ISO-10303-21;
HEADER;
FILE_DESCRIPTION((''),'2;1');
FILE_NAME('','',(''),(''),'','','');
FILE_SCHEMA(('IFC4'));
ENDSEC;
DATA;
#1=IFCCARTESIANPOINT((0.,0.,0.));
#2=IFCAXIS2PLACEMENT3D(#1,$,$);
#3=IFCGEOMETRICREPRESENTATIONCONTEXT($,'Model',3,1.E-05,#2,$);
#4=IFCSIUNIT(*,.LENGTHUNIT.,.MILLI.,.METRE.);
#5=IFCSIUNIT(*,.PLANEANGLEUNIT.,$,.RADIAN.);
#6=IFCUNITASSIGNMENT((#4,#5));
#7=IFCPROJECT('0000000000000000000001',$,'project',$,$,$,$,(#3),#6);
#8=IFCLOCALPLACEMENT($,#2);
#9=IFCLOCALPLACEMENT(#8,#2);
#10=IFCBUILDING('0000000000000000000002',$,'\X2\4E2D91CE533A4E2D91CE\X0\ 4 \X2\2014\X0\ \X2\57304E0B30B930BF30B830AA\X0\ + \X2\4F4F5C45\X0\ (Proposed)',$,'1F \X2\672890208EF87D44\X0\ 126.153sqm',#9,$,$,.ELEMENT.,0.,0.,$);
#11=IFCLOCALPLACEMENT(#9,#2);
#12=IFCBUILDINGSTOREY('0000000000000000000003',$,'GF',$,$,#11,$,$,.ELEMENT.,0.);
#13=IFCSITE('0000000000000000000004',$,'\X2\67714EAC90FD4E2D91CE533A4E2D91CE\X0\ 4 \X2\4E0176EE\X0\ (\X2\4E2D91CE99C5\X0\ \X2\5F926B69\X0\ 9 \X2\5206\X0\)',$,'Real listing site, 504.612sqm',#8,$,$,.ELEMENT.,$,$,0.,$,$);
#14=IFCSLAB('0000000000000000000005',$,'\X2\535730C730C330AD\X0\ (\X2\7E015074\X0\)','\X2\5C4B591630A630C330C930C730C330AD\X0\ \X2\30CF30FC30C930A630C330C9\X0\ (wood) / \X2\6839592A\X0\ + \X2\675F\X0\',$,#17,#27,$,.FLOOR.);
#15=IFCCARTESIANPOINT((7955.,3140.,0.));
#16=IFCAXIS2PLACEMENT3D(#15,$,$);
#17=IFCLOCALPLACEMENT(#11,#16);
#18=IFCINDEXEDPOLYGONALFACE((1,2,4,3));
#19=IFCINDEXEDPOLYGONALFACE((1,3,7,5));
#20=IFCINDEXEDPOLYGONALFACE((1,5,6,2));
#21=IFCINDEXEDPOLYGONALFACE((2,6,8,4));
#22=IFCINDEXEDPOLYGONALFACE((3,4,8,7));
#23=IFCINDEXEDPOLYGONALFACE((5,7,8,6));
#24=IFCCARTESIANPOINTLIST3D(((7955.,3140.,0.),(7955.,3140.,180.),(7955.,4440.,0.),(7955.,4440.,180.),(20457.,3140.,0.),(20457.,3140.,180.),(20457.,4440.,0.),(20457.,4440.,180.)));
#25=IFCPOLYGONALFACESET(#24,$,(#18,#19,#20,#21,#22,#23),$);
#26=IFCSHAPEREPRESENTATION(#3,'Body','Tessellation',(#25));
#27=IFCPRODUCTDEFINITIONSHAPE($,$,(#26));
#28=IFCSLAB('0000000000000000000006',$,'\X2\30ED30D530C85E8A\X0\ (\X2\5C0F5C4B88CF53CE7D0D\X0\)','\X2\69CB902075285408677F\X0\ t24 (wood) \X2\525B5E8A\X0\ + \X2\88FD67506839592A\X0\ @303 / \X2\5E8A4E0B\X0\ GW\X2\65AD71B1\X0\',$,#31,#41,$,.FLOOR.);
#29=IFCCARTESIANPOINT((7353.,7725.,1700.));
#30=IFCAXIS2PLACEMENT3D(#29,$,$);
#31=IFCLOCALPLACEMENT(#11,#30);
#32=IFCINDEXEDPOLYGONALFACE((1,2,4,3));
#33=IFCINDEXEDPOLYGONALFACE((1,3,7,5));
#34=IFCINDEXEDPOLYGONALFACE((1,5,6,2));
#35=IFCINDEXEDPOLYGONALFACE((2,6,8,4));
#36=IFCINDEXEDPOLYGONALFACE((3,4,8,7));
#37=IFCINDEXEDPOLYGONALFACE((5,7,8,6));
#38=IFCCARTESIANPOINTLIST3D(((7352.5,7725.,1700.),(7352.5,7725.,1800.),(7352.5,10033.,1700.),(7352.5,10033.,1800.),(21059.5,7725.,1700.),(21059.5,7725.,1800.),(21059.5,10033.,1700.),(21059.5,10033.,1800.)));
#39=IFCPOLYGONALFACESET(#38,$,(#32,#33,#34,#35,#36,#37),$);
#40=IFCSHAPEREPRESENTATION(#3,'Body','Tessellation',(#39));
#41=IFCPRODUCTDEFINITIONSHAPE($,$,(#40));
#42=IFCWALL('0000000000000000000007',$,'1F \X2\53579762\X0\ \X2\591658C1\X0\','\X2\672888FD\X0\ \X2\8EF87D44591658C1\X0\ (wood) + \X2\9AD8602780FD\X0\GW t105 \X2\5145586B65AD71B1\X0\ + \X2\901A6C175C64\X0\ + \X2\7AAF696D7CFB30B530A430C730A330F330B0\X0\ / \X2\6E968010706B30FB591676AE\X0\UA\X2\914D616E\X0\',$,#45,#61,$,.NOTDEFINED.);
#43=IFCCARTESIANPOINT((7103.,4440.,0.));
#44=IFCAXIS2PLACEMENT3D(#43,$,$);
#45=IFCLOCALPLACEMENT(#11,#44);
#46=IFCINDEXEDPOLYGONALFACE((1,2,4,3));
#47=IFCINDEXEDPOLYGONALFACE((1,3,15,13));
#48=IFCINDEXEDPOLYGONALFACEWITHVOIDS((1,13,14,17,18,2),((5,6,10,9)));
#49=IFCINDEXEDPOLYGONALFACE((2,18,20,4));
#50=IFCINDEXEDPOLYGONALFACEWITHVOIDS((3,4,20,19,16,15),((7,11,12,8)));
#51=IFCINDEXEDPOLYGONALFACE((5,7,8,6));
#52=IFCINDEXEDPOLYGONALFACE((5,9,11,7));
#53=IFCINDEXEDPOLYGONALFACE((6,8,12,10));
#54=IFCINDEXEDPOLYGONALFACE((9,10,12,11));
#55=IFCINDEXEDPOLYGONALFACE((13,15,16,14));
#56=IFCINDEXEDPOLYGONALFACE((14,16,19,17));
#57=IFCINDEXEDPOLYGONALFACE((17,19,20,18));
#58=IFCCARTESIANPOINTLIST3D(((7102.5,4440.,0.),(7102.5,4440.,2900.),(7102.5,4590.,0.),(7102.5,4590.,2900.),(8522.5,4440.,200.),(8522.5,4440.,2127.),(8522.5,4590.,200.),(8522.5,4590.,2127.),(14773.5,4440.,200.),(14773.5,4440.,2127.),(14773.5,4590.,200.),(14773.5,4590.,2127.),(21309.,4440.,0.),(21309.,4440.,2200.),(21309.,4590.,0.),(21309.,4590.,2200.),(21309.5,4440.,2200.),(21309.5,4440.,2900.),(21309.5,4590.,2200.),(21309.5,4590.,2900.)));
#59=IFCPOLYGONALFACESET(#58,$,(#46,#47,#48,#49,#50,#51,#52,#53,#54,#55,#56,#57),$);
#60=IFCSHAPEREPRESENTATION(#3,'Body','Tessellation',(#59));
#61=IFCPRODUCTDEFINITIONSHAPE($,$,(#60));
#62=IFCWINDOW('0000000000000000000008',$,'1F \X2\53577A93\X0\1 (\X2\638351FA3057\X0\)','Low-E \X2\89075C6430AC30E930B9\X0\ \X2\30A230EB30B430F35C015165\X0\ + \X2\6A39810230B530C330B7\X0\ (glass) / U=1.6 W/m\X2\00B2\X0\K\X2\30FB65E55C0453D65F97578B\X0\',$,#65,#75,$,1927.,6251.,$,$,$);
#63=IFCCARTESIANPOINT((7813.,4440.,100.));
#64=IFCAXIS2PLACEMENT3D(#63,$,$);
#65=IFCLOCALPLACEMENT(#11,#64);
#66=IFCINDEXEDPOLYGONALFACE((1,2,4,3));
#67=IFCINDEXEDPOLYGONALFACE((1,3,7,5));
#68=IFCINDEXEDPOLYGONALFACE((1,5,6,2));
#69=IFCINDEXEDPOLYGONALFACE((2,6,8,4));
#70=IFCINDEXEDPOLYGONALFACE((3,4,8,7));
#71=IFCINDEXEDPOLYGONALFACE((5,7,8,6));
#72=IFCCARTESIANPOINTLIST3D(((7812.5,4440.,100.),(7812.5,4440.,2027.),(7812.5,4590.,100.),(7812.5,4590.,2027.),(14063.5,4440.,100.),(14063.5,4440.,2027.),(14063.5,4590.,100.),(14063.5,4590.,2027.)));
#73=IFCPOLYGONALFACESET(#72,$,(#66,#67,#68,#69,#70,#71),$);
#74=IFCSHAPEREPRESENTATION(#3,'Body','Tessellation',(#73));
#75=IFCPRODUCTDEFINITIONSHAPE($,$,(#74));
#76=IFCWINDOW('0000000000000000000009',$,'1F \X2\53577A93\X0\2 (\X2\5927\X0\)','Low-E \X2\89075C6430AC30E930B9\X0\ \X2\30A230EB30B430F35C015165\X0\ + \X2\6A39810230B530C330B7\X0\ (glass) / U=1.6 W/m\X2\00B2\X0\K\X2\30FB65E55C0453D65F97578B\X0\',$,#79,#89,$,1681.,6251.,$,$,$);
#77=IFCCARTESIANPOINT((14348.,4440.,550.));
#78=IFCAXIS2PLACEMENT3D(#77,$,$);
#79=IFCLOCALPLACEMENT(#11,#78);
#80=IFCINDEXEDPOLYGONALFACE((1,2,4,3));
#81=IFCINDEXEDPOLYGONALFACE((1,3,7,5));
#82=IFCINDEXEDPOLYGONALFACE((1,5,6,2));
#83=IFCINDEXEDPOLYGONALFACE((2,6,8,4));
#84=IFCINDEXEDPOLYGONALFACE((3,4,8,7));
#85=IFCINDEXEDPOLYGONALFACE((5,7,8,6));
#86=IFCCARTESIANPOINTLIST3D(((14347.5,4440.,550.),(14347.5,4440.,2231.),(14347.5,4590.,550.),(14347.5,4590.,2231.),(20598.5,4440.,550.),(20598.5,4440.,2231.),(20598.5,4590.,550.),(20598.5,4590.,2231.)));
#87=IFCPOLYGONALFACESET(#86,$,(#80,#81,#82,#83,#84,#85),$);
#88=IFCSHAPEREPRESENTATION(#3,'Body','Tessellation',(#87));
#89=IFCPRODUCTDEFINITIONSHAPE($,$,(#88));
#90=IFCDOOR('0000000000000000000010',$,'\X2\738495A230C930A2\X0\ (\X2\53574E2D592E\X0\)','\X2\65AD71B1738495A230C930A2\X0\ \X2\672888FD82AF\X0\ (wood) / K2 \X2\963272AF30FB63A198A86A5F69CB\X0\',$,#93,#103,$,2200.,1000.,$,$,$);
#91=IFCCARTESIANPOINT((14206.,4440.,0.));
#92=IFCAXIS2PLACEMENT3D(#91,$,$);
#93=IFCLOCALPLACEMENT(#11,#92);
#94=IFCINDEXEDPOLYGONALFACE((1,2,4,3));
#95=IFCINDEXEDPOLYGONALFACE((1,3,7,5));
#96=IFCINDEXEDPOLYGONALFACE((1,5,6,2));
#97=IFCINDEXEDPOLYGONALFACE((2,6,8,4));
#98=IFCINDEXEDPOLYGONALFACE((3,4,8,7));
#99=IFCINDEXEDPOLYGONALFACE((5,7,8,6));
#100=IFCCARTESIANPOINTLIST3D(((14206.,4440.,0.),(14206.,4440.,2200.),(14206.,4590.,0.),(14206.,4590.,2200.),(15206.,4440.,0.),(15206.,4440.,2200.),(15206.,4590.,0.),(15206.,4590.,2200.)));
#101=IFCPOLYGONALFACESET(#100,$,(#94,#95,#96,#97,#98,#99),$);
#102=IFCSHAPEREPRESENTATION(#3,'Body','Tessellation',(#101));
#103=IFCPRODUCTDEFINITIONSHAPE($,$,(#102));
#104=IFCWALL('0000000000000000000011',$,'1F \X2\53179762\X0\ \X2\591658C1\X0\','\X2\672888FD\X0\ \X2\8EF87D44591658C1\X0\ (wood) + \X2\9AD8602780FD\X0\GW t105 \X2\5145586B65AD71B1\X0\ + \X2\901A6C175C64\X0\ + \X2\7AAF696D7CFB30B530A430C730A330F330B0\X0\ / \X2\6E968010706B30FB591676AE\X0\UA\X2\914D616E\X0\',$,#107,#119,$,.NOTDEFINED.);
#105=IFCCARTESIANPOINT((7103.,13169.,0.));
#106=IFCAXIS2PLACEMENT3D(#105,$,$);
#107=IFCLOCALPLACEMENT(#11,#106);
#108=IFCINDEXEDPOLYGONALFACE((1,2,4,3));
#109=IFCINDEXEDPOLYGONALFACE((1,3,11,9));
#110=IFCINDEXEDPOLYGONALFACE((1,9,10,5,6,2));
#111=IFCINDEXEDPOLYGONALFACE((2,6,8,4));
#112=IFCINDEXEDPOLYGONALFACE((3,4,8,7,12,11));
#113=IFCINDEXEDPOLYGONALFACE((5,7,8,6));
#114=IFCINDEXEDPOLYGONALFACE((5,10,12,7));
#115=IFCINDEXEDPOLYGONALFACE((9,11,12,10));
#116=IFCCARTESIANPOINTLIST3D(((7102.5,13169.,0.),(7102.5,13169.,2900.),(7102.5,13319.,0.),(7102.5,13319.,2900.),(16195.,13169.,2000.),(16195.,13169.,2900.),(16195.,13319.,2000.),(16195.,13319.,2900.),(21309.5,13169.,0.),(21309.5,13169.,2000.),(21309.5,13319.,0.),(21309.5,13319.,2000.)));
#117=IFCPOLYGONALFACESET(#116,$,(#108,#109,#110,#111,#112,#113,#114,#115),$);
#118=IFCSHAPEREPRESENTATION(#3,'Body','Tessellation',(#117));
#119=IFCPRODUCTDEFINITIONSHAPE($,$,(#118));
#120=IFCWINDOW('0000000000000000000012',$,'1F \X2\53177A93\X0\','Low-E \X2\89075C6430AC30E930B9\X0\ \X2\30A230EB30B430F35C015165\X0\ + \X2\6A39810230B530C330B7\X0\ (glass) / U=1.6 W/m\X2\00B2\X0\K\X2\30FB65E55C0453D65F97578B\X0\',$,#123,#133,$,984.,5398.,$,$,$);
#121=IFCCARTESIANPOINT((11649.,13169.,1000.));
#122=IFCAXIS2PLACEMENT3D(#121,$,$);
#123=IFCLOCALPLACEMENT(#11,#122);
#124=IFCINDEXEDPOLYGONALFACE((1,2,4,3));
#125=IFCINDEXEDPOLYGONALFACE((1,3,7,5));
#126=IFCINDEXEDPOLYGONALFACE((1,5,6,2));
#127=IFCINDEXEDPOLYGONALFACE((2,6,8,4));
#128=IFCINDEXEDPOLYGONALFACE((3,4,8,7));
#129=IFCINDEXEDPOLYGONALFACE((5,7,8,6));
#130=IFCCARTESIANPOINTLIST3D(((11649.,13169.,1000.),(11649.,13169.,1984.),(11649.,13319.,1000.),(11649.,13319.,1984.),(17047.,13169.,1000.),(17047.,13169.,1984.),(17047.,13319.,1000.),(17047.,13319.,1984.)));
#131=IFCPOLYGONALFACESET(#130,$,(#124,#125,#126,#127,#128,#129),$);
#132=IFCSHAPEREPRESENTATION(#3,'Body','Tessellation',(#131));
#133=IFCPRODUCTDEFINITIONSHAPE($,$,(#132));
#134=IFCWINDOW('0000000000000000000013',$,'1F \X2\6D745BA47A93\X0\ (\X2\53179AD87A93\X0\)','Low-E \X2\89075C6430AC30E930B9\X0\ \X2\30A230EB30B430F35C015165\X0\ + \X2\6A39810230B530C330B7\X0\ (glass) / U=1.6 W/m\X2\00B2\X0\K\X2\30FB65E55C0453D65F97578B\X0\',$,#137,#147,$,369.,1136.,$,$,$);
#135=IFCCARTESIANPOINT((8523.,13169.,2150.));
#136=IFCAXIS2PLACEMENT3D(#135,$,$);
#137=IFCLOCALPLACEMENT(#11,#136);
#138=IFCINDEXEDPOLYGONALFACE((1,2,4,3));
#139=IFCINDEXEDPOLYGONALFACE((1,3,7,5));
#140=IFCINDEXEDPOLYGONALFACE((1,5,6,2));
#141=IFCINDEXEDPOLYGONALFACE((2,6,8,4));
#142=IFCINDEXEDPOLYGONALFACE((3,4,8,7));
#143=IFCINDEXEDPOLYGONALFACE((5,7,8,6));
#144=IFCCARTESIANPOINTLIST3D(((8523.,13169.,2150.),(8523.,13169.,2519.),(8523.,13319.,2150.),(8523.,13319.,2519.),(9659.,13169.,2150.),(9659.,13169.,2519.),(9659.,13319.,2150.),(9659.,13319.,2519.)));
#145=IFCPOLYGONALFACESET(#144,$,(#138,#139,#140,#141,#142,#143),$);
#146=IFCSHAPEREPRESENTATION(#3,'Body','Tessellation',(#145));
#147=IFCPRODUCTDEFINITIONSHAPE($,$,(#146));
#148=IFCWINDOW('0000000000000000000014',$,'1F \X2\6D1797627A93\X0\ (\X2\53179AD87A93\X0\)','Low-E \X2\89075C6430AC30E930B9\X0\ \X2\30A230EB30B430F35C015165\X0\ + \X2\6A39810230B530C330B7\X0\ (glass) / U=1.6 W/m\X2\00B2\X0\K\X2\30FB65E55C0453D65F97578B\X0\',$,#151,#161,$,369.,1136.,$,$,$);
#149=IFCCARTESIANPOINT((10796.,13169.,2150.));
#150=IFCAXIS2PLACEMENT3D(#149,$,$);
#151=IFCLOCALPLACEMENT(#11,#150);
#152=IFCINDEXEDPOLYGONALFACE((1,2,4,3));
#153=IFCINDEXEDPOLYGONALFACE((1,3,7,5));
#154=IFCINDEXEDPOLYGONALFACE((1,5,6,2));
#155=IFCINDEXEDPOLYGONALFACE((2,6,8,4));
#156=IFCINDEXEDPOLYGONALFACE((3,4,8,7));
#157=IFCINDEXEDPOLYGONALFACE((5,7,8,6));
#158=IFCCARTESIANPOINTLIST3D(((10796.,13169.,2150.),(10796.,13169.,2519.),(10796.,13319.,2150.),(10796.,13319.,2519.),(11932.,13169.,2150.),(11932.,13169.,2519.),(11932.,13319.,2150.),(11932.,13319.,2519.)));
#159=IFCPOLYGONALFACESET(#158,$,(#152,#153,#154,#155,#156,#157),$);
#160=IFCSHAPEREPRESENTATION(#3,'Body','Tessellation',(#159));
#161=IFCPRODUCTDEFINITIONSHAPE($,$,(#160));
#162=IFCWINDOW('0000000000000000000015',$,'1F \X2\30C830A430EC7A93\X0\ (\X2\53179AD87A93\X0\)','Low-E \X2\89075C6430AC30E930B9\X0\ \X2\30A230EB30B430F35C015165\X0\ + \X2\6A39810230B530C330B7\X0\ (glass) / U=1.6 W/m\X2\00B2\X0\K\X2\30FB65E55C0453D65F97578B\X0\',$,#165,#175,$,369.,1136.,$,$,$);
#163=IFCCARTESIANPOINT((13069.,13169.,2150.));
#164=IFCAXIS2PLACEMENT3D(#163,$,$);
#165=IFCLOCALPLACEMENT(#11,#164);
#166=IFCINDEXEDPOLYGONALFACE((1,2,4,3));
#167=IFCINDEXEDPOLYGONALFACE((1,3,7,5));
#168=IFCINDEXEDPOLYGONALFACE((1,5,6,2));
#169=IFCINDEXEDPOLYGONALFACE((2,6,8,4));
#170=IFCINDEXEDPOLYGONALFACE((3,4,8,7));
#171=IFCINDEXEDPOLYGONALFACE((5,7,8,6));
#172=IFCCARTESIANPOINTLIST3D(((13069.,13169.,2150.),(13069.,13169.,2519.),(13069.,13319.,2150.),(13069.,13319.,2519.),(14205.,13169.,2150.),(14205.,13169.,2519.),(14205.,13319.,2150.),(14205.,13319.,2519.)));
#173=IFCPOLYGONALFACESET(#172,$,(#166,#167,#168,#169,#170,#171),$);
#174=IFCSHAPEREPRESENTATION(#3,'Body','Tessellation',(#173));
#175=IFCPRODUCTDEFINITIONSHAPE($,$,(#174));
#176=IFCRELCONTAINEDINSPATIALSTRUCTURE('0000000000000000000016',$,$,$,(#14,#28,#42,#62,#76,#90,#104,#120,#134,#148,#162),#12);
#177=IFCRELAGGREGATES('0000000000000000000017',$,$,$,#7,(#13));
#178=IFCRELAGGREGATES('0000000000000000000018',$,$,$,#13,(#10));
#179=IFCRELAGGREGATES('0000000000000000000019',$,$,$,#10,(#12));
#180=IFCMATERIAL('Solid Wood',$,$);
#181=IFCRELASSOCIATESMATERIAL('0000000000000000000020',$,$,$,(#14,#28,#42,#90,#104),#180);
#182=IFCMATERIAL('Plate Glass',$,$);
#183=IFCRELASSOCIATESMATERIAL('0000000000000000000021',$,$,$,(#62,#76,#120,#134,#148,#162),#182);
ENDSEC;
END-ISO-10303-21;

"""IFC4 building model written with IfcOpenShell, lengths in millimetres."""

from ifc_helpers import new_model, si_unit, frame, frame_2d, origin, place, context, project, spatial, rectangle, extrude, material, element, fill, save


model = new_model("IFC4")

# Units and contexts
model_context = context("Model", 3, precision=1e-05, world=origin())
ifc_project = project(units=[si_unit("LENGTHUNIT", "METRE", prefix="MILLI"), si_unit("PLANEANGLEUNIT", "RADIAN")], contexts=[model_context])

# Site, building, storey
site_placement = place(None, origin())
site = spatial("IfcSite", under=ifc_project, at=site_placement, Name="東京都中野区中野 4 丁目 (中野駅 徒歩 9 分)", ObjectType="Real listing site, 504.612sqm", CompositionType="ELEMENT", RefElevation=0.0)
building_placement = place(site_placement, origin())
building = spatial("IfcBuilding", under=site, at=building_placement, Name="中野区中野 4 — 地下スタジオ + 住居 (Proposed)", ObjectType="1F 木造軸組 126.153sqm", CompositionType="ELEMENT", ElevationOfRefHeight=0.0, ElevationOfTerrain=0.0)
storey_placement = place(building_placement, origin())
storey = spatial("IfcBuildingStorey", under=building, at=storey_placement, Name="GF", CompositionType="ELEMENT", Elevation=0.0)

# Slabs
ifc_material_1 = material(Name="Solid Wood")
slab_1_placement = place(storey_placement, frame((7955.0, 3140.0, 0.0)))
element("IfcSlab", 1, at=slab_1_placement, inside=storey, material=ifc_material_1, Name="南デッキ (縁側)", Description="屋外ウッドデッキ ハードウッド (wood) / 根太 + 束", PredefinedType="FLOOR", context=model_context, shape_type="SweptSolid", body=[
    extrude(rectangle(XDim=12502.0, YDim=1300.0, at=frame_2d((6251.0, 650.0))), frame((7955.0, 3140.0, 0.0)), (0.0, 0.0, 1.0), 180.0),
])
slab_2_placement = place(storey_placement, frame((7353.0, 7725.0, 1700.0)))
element("IfcSlab", 2, at=slab_2_placement, inside=storey, material=ifc_material_1, Name="ロフト床 (小屋裏収納)", Description="構造用合板 t24 (wood) 剛床 + 製材根太 @303 / 床下 GW断熱", PredefinedType="FLOOR", context=model_context, shape_type="SweptSolid", body=[
    extrude(rectangle(XDim=13707.0, YDim=2308.0, at=frame_2d((6853.0, 1154.0))), frame((7353.0, 7725.0, 1700.0)), (0.0, 0.0, 1.0), 100.0),
])

# Wall, openings, windows, door
wall_1_placement = place(storey_placement, frame((7103.0, 4440.0, 0.0)))
wall_1 = element("IfcWall", 3, at=wall_1_placement, inside=storey, material=ifc_material_1, Name="1F 南面 外壁", Description="木製 軸組外壁 (wood) + 高性能GW t105 充填断熱 + 通気層 + 窯業系サイディング / 準耐火・外皮UA配慮", PredefinedType="NOTDEFINED", context=model_context, shape_type="SweptSolid", body=[
    extrude(rectangle(XDim=14207.0, YDim=150.0, at=frame_2d((7103.0, 75.0))), frame((7103.0, 4440.0, 0.0)), (0.0, 0.0, 1.0), 2900.0),
])
opening_1_placement = place(storey_placement, frame((7813.0, 4440.0, 100.0)))
opening_1 = element("IfcOpeningElement", 4, at=opening_1_placement, cuts=wall_1, PredefinedType="NOTDEFINED", context=model_context, shape_type="SweptSolid", body=[
    extrude(rectangle(XDim=6251.0, YDim=150.0, at=frame_2d((3125.0, 75.0))), frame((7813.0, 4440.0, 100.0)), (0.0, 0.0, 1.0), 1927.0),
])
opening_2_placement = place(storey_placement, frame((14348.0, 4440.0, 550.0)))
opening_2 = element("IfcOpeningElement", 5, at=opening_2_placement, cuts=wall_1, PredefinedType="NOTDEFINED", context=model_context, shape_type="SweptSolid", body=[
    extrude(rectangle(XDim=6251.0, YDim=150.0, at=frame_2d((3125.0, 75.0))), frame((14348.0, 4440.0, 550.0)), (0.0, 0.0, 1.0), 1681.0),
])
opening_3_placement = place(storey_placement, frame((14206.0, 4440.0, 0.0)))
opening_3 = element("IfcOpeningElement", 6, at=opening_3_placement, cuts=wall_1, PredefinedType="NOTDEFINED", context=model_context, shape_type="SweptSolid", body=[
    extrude(rectangle(XDim=1000.0, YDim=150.0, at=frame_2d((500.0, 75.0))), frame((14206.0, 4440.0, 0.0)), (0.0, 0.0, 1.0), 2200.0),
])
ifc_material_2 = material(Name="Plate Glass")
window_1_placement = place(storey_placement, frame((7813.0, 4440.0, 100.0)))
window_1 = element("IfcWindow", 7, at=window_1_placement, inside=storey, material=ifc_material_2, Name="1F 南窓1 (掃出し)", Description="Low-E 複層ガラス アルゴン封入 + 樹脂サッシ (glass) / U=1.6 W/m²K・日射取得型", OverallHeight=1927.0, OverallWidth=6251.0, context=model_context, shape_type="SweptSolid", body=[
    extrude(rectangle(XDim=6251.0, YDim=150.0, at=frame_2d((3125.0, 75.0))), frame((7813.0, 4440.0, 100.0)), (0.0, 0.0, 1.0), 1927.0),
])
fill(opening_1, window_1)
window_2_placement = place(storey_placement, frame((14348.0, 4440.0, 550.0)))
window_2 = element("IfcWindow", 8, at=window_2_placement, inside=storey, material=ifc_material_2, Name="1F 南窓2 (大)", Description="Low-E 複層ガラス アルゴン封入 + 樹脂サッシ (glass) / U=1.6 W/m²K・日射取得型", OverallHeight=1681.0, OverallWidth=6251.0, context=model_context, shape_type="SweptSolid", body=[
    extrude(rectangle(XDim=6251.0, YDim=150.0, at=frame_2d((3125.0, 75.0))), frame((14348.0, 4440.0, 550.0)), (0.0, 0.0, 1.0), 1681.0),
])
fill(opening_2, window_2)
door_1_placement = place(storey_placement, frame((14206.0, 4440.0, 0.0)))
door_1 = element("IfcDoor", 9, at=door_1_placement, inside=storey, material=ifc_material_1, Name="玄関ドア (南中央)", Description="断熱玄関ドア 木製芯 (wood) / K2 防犯・採風機構", OverallHeight=2200.0, OverallWidth=1000.0, context=model_context, shape_type="SweptSolid", body=[
    extrude(rectangle(XDim=1000.0, YDim=150.0, at=frame_2d((500.0, 75.0))), frame((14206.0, 4440.0, 0.0)), (0.0, 0.0, 1.0), 2200.0),
])
fill(opening_3, door_1)

# Wall, openings, windows
wall_2_placement = place(storey_placement, frame((7103.0, 13169.0, 0.0)))
wall_2 = element("IfcWall", 10, at=wall_2_placement, inside=storey, material=ifc_material_1, Name="1F 北面 外壁", Description="木製 軸組外壁 (wood) + 高性能GW t105 充填断熱 + 通気層 + 窯業系サイディング / 準耐火・外皮UA配慮", PredefinedType="NOTDEFINED", context=model_context, shape_type="SweptSolid", body=[
    extrude(rectangle(XDim=14207.0, YDim=150.0, at=frame_2d((7103.0, 75.0))), frame((7103.0, 13169.0, 0.0)), (0.0, 0.0, 1.0), 2900.0),
])
opening_4_placement = place(storey_placement, frame((11649.0, 13169.0, 1000.0)))
opening_4 = element("IfcOpeningElement", 11, at=opening_4_placement, cuts=wall_2, PredefinedType="NOTDEFINED", context=model_context, shape_type="SweptSolid", body=[
    extrude(rectangle(XDim=5398.0, YDim=150.0, at=frame_2d((2699.0, 75.0))), frame((11649.0, 13169.0, 1000.0)), (0.0, 0.0, 1.0), 984.0),
])
opening_5_placement = place(storey_placement, frame((8523.0, 13169.0, 2150.0)))
opening_5 = element("IfcOpeningElement", 12, at=opening_5_placement, cuts=wall_2, PredefinedType="NOTDEFINED", context=model_context, shape_type="SweptSolid", body=[
    extrude(rectangle(XDim=1136.0, YDim=150.0, at=frame_2d((568.0, 75.0))), frame((8523.0, 13169.0, 2150.0)), (0.0, 0.0, 1.0), 369.0),
])
opening_6_placement = place(storey_placement, frame((10796.0, 13169.0, 2150.0)))
opening_6 = element("IfcOpeningElement", 13, at=opening_6_placement, cuts=wall_2, PredefinedType="NOTDEFINED", context=model_context, shape_type="SweptSolid", body=[
    extrude(rectangle(XDim=1136.0, YDim=150.0, at=frame_2d((568.0, 75.0))), frame((10796.0, 13169.0, 2150.0)), (0.0, 0.0, 1.0), 369.0),
])
opening_7_placement = place(storey_placement, frame((13069.0, 13169.0, 2150.0)))
opening_7 = element("IfcOpeningElement", 14, at=opening_7_placement, cuts=wall_2, PredefinedType="NOTDEFINED", context=model_context, shape_type="SweptSolid", body=[
    extrude(rectangle(XDim=1136.0, YDim=150.0, at=frame_2d((568.0, 75.0))), frame((13069.0, 13169.0, 2150.0)), (0.0, 0.0, 1.0), 369.0),
])
window_3_placement = place(storey_placement, frame((11649.0, 13169.0, 1000.0)))
window_3 = element("IfcWindow", 15, at=window_3_placement, inside=storey, material=ifc_material_2, Name="1F 北窓", Description="Low-E 複層ガラス アルゴン封入 + 樹脂サッシ (glass) / U=1.6 W/m²K・日射取得型", OverallHeight=984.0, OverallWidth=5398.0, context=model_context, shape_type="SweptSolid", body=[
    extrude(rectangle(XDim=5398.0, YDim=150.0, at=frame_2d((2699.0, 75.0))), frame((11649.0, 13169.0, 1000.0)), (0.0, 0.0, 1.0), 984.0),
])
fill(opening_4, window_3)
window_4_placement = place(storey_placement, frame((8523.0, 13169.0, 2150.0)))
window_4 = element("IfcWindow", 16, at=window_4_placement, inside=storey, material=ifc_material_2, Name="1F 浴室窓 (北高窓)", Description="Low-E 複層ガラス アルゴン封入 + 樹脂サッシ (glass) / U=1.6 W/m²K・日射取得型", OverallHeight=369.0, OverallWidth=1136.0, context=model_context, shape_type="SweptSolid", body=[
    extrude(rectangle(XDim=1136.0, YDim=150.0, at=frame_2d((568.0, 75.0))), frame((8523.0, 13169.0, 2150.0)), (0.0, 0.0, 1.0), 369.0),
])
fill(opening_5, window_4)
window_5_placement = place(storey_placement, frame((10796.0, 13169.0, 2150.0)))
window_5 = element("IfcWindow", 17, at=window_5_placement, inside=storey, material=ifc_material_2, Name="1F 洗面窓 (北高窓)", Description="Low-E 複層ガラス アルゴン封入 + 樹脂サッシ (glass) / U=1.6 W/m²K・日射取得型", OverallHeight=369.0, OverallWidth=1136.0, context=model_context, shape_type="SweptSolid", body=[
    extrude(rectangle(XDim=1136.0, YDim=150.0, at=frame_2d((568.0, 75.0))), frame((10796.0, 13169.0, 2150.0)), (0.0, 0.0, 1.0), 369.0),
])
fill(opening_6, window_5)
window_6_placement = place(storey_placement, frame((13069.0, 13169.0, 2150.0)))
window_6 = element("IfcWindow", 18, at=window_6_placement, inside=storey, material=ifc_material_2, Name="1F トイレ窓 (北高窓)", Description="Low-E 複層ガラス アルゴン封入 + 樹脂サッシ (glass) / U=1.6 W/m²K・日射取得型", OverallHeight=369.0, OverallWidth=1136.0, context=model_context, shape_type="SweptSolid", body=[
    extrude(rectangle(XDim=1136.0, YDim=150.0, at=frame_2d((568.0, 75.0))), frame((13069.0, 13169.0, 2150.0)), (0.0, 0.0, 1.0), 369.0),
])
fill(opening_7, window_6)

save(model, "model.ifc")
